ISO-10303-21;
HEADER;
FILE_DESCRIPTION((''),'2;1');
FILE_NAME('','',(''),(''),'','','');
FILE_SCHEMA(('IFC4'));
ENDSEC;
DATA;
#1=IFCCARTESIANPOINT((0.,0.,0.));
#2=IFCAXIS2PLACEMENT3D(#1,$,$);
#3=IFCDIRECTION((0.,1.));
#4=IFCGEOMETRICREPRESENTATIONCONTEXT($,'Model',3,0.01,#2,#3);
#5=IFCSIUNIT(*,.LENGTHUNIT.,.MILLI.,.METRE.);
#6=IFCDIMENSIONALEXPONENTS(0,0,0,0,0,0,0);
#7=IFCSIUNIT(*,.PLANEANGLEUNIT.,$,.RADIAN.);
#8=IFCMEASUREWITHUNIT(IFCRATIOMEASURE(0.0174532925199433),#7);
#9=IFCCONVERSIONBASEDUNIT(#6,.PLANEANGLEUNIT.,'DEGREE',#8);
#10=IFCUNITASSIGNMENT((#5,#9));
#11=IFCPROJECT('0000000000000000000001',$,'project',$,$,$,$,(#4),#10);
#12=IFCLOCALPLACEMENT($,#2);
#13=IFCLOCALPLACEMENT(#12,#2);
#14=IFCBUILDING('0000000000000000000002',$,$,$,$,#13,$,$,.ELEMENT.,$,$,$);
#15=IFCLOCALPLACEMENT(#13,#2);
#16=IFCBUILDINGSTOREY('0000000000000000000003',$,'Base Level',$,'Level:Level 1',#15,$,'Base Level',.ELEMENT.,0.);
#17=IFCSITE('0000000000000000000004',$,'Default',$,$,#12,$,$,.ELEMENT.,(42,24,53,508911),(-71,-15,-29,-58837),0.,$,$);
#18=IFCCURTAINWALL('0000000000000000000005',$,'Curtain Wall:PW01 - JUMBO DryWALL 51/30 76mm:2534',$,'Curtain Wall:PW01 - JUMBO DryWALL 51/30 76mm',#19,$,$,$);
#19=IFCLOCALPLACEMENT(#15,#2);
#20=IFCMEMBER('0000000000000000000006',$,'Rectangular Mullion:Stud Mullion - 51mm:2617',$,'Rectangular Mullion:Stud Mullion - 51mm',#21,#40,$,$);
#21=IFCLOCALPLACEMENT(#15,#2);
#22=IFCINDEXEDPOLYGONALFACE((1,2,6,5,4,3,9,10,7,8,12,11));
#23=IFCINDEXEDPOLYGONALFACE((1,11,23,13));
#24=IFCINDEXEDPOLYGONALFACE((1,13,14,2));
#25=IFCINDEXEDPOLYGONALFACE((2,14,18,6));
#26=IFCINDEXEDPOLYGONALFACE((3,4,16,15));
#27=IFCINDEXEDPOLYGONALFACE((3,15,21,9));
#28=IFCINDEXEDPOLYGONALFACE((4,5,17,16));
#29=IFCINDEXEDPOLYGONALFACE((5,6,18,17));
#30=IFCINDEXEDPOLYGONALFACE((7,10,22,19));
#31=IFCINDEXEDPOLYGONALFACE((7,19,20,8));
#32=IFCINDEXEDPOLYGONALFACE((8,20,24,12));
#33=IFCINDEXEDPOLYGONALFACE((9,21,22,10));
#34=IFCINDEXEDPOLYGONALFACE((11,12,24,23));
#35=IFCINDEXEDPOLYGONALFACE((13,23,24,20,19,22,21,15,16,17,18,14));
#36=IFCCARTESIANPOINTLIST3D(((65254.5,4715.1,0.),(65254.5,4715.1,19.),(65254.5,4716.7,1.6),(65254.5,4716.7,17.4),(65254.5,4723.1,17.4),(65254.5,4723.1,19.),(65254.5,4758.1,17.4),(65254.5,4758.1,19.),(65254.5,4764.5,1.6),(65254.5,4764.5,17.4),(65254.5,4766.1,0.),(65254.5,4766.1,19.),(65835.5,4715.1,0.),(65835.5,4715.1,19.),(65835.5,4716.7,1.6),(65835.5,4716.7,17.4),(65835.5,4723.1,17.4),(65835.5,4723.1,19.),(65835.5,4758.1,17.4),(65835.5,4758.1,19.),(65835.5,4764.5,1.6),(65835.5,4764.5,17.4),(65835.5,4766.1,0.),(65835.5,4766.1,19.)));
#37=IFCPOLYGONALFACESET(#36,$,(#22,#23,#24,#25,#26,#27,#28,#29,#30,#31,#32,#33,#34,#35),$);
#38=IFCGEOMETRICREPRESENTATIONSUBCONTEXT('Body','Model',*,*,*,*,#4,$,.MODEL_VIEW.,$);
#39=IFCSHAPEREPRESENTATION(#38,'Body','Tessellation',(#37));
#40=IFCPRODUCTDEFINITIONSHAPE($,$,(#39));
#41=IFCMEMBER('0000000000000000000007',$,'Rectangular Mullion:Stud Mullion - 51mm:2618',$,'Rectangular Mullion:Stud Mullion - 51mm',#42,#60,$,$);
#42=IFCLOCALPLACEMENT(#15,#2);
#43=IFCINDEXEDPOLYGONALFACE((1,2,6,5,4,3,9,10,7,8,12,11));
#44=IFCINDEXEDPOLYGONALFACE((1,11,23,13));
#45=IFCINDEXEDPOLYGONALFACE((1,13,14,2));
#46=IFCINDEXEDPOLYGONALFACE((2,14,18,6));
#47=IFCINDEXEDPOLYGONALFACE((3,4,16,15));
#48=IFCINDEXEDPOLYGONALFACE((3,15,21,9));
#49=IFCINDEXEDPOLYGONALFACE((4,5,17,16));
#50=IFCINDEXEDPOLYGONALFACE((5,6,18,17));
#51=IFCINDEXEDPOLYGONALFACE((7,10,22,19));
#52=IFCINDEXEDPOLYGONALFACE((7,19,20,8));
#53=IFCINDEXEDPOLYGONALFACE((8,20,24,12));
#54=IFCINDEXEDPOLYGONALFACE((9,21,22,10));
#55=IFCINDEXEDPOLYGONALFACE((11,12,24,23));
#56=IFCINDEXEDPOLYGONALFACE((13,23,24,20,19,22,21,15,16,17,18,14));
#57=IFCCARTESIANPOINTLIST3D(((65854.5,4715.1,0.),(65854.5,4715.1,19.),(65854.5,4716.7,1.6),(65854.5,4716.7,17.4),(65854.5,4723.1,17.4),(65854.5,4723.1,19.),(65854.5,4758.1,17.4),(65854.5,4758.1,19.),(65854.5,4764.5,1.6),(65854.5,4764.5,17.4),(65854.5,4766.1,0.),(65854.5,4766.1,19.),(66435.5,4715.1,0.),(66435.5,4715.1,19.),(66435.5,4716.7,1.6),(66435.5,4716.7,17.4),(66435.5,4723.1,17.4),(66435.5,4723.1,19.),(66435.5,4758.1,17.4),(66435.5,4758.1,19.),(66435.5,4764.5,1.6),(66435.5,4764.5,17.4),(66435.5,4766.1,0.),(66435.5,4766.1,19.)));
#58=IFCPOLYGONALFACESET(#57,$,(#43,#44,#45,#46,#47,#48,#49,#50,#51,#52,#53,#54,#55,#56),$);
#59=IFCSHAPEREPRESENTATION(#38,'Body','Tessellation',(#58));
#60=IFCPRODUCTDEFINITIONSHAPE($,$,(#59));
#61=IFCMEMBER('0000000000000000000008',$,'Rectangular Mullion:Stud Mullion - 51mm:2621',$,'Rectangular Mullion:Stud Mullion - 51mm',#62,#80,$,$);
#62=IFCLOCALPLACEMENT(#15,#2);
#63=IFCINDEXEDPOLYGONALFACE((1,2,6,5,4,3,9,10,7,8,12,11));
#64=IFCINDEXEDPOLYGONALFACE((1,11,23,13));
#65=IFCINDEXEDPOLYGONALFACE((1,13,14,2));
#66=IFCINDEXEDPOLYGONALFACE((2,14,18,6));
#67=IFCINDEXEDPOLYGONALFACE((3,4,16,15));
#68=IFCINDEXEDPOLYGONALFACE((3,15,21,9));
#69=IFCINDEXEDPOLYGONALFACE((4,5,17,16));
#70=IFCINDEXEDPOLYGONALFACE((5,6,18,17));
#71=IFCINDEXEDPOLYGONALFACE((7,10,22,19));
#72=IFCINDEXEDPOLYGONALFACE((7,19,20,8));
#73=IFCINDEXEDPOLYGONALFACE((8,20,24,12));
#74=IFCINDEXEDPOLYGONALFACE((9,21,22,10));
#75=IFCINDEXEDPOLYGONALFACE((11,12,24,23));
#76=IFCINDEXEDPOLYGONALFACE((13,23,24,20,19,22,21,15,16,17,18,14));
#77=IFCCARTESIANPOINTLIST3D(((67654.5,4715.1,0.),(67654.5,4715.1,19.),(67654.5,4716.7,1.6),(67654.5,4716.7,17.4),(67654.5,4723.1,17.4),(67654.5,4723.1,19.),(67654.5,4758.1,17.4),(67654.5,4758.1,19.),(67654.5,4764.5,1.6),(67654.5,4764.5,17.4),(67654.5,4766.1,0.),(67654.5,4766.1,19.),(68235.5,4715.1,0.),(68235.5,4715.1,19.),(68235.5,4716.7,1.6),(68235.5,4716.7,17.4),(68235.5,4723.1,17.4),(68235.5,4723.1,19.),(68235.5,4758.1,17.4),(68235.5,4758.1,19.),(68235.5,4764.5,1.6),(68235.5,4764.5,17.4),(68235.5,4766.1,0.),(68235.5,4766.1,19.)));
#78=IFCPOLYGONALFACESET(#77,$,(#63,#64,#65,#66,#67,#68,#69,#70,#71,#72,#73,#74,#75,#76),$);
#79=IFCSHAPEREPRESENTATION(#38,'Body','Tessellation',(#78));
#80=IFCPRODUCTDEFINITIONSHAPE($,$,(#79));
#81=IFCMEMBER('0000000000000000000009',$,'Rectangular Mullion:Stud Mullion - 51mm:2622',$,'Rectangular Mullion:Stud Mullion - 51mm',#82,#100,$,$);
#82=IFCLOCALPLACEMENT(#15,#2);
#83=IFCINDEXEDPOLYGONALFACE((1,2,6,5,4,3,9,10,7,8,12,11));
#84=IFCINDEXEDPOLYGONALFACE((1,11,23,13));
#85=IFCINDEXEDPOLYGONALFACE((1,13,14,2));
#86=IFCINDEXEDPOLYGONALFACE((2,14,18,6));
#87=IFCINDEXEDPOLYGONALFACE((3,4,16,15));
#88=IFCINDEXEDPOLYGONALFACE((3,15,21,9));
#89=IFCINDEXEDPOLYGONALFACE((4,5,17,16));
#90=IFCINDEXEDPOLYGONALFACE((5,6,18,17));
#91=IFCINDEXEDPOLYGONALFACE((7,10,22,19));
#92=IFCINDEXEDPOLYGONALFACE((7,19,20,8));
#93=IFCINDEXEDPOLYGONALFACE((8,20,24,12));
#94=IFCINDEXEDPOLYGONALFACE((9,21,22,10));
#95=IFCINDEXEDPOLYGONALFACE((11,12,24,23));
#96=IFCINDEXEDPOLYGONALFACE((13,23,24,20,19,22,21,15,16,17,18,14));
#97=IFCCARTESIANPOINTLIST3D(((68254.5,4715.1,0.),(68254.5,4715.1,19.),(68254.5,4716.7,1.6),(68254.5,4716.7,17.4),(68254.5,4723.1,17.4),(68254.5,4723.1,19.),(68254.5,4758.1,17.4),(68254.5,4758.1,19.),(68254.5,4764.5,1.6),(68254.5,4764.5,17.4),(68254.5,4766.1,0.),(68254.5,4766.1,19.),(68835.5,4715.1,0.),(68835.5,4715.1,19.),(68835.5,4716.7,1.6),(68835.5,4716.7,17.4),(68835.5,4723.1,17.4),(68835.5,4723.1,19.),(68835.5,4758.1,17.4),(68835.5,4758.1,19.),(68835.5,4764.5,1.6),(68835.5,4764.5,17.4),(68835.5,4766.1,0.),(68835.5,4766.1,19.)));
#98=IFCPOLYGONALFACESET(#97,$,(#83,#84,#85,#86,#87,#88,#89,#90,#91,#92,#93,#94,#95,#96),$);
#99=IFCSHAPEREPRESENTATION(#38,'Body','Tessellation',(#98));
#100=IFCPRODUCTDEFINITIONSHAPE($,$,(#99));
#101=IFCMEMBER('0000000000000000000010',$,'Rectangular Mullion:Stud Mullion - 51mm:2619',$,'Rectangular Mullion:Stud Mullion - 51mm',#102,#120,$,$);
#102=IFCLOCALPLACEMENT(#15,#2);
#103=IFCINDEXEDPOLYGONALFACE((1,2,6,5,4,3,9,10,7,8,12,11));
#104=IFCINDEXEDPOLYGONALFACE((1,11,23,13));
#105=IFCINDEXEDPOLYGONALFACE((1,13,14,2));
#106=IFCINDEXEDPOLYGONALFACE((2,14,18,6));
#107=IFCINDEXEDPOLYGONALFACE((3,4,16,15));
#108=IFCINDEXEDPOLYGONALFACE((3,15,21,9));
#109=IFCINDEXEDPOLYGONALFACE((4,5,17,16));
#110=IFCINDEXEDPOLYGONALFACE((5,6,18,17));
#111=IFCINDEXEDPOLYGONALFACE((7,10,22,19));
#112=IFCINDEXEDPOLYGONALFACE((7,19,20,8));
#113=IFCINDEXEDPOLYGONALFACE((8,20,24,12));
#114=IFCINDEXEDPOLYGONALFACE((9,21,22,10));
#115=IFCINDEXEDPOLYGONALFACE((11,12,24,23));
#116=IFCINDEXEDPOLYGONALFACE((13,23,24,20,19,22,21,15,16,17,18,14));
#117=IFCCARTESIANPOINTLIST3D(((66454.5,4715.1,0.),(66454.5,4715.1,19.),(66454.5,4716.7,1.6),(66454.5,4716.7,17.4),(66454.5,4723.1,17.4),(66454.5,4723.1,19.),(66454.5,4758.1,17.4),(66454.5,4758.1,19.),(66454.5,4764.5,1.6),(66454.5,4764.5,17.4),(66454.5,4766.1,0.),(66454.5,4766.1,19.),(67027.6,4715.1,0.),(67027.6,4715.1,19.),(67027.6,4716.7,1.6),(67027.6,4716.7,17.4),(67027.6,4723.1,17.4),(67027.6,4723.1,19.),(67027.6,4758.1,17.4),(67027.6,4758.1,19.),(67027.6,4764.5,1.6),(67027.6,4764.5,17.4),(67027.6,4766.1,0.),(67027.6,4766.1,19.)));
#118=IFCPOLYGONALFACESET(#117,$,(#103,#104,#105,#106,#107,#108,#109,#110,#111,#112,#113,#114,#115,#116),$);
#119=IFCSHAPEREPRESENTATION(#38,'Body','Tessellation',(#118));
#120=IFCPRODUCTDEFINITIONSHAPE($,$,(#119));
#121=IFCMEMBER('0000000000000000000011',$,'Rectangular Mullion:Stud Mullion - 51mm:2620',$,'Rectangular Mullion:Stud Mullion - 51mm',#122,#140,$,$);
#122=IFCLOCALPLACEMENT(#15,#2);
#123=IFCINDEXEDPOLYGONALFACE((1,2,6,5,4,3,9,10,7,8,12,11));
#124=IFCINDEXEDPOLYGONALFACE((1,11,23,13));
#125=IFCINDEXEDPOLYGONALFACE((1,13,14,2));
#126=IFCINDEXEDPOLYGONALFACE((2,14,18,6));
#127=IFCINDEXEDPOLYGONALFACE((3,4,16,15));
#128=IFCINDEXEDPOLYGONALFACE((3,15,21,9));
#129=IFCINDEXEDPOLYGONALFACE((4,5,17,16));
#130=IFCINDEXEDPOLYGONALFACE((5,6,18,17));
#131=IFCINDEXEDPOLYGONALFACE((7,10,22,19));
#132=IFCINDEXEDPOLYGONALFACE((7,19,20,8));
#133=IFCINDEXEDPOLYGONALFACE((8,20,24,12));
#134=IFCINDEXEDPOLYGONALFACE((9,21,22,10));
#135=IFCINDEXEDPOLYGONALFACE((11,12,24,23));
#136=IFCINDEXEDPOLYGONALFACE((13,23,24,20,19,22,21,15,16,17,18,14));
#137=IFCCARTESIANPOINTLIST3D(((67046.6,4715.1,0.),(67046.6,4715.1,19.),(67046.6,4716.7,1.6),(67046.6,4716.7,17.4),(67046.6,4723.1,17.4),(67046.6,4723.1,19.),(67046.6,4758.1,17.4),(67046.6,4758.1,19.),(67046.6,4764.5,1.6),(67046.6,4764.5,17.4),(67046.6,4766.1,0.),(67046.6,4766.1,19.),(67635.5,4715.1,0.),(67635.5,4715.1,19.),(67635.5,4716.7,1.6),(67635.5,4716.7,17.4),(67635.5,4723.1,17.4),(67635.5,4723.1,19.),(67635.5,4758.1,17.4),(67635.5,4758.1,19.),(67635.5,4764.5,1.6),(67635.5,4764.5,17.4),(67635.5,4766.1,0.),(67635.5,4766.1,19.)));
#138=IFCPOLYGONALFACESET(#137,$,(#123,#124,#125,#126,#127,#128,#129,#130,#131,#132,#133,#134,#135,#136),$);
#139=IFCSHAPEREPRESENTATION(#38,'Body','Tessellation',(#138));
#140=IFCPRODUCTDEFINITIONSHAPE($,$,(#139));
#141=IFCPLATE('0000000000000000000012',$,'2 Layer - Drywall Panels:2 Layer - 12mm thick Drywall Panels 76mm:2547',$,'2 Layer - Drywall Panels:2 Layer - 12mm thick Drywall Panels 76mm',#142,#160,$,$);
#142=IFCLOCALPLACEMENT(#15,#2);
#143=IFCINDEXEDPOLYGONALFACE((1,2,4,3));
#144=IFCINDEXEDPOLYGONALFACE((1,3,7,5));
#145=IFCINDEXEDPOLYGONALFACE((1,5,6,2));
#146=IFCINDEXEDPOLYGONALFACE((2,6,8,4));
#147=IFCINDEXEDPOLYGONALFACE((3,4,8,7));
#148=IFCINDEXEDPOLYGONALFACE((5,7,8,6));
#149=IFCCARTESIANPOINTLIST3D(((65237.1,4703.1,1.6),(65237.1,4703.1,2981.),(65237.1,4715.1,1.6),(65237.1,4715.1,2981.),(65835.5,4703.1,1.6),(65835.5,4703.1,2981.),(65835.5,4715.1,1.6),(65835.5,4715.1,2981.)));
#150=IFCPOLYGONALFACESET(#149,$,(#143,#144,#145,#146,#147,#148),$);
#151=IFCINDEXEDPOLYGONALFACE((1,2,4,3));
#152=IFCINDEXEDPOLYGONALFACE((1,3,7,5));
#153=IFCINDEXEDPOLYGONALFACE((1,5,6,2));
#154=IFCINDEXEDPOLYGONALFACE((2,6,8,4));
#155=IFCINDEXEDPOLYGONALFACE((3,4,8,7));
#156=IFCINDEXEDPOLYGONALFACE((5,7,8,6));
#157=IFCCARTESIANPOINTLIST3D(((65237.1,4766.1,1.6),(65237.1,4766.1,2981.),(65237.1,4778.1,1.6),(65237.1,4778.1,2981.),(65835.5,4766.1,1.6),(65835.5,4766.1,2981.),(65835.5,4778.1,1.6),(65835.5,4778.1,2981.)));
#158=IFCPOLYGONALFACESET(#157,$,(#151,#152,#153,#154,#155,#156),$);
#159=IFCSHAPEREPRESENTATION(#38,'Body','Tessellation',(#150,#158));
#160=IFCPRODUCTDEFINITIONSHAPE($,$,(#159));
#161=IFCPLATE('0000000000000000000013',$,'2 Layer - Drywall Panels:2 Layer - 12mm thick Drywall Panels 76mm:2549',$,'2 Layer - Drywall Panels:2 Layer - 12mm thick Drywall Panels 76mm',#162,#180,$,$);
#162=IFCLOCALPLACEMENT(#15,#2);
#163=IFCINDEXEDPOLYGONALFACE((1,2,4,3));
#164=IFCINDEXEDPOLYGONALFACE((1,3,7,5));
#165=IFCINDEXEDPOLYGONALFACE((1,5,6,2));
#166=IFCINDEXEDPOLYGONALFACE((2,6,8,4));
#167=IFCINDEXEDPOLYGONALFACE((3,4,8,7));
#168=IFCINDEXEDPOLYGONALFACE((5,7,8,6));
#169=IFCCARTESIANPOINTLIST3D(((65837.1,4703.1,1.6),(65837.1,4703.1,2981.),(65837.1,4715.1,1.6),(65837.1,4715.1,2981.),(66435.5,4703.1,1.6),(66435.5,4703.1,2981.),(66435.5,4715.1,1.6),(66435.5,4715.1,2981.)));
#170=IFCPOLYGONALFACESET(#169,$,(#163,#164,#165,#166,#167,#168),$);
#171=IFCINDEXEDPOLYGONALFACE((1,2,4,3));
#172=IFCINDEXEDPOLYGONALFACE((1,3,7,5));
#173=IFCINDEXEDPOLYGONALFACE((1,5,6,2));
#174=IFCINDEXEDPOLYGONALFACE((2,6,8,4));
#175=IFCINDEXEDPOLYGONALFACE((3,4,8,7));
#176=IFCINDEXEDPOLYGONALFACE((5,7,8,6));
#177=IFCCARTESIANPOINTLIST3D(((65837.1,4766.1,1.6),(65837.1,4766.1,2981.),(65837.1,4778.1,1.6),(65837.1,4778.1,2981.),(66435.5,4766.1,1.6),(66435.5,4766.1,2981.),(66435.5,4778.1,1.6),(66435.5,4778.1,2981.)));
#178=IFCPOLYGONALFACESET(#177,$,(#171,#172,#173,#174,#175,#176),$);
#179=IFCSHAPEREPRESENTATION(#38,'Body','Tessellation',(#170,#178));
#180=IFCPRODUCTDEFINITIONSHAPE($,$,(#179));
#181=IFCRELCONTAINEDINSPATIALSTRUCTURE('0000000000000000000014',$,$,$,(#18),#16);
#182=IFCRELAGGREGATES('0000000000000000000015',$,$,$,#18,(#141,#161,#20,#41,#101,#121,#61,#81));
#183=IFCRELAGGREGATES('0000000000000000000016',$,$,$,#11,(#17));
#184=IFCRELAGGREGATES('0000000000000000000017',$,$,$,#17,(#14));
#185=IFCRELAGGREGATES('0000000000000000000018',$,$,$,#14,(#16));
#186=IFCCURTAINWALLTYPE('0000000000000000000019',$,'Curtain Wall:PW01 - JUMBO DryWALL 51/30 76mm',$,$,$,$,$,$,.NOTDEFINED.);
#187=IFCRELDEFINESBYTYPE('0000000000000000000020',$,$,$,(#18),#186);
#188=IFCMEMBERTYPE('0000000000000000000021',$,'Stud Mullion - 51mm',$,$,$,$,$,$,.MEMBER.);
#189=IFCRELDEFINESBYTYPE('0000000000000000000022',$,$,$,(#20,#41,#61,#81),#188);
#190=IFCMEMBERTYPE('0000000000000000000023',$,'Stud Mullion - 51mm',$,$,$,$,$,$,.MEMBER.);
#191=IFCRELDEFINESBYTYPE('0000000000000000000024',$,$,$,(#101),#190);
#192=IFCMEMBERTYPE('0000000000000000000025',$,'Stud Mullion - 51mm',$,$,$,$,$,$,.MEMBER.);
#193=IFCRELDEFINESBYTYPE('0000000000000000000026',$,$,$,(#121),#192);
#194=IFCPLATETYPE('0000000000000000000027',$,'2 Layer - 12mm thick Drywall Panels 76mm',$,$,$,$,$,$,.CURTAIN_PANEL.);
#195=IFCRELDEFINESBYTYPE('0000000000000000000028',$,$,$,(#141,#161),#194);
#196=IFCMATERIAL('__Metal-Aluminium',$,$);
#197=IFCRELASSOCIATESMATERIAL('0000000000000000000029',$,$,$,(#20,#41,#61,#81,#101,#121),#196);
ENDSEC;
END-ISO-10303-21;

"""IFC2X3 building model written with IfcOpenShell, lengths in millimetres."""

from ifc_helpers import new_model, entity, si_unit, converted_unit, direction, frame, frame_2d, origin, origin_2d_with_axis, place, context, subcontext, project, spatial, polyline, rectangle, outline, extrude, source, transform, mapped, material, type_object, type_shapes, element, aggregate, save


model = new_model("IFC2X3")

# Units and contexts
model_context = context("Model", 3, precision=0.01, world=origin(), true_north=direction((0.0, 1.0)))
body_context = subcontext(model_context, "Body", "Model", "MODEL_VIEW")
ifc_project = project(units=[si_unit("LENGTHUNIT", "METRE", prefix="MILLI"), converted_unit("PLANEANGLEUNIT", "DEGREE", entity("IfcRatioMeasure", 0.0174532925199433), si_unit("PLANEANGLEUNIT", "RADIAN"), dimensions=[0, 0, 0, 0, 0, 0, 0])], contexts=[model_context])

# Site, building, storey
site_placement = place(None, origin())
site = spatial("IfcSite", under=ifc_project, at=site_placement, Name="Default", CompositionType="ELEMENT", RefLatitude=(42, 24, 53, 508911), RefLongitude=(-71, -15, -29, -58837), RefElevation=0.0)
building_placement = place(site_placement, origin())
building = spatial("IfcBuilding", under=site, at=building_placement, CompositionType="ELEMENT")
storey_placement = place(building_placement, origin())
storey = spatial("IfcBuildingStorey", under=building, at=storey_placement, Name="Base Level", ObjectType="Level:Level 1", LongName="Base Level", CompositionType="ELEMENT", Elevation=0.0)

# Curtain wall, members, plates
curtain_wall_type = type_object("IfcCurtainWallType", Name="Curtain Wall:PW01 - JUMBO DryWALL 51/30 76mm", PredefinedType="NOTDEFINED")
curtain_wall_placement = place(building_placement, origin())
curtain_wall = element("IfcCurtainWall", 1, at=curtain_wall_placement, inside=storey, type_object=curtain_wall_type, Name="Curtain Wall:PW01 - JUMBO DryWALL 51/30 76mm:2534", ObjectType="Curtain Wall:PW01 - JUMBO DryWALL 51/30 76mm")
ifc_material = material(Name="__Metal-Aluminium")
member_type_1 = type_object("IfcMemberType", Name="Stud Mullion - 51mm", PredefinedType="MEMBER")
shared_shape_1 = source(origin(), body_context, "Body", "SweptSolid", [
    extrude(outline(polyline([(17.5, -6.6), (25.5, -6.6), (25.5, 12.4), (-25.5, 12.4), (-25.5, -6.6), (-17.5, -6.6), (-17.5, -5.0), (-23.9, -5.0), (-23.9, 10.8), (23.9, 10.8), (23.9, -5.0), (17.5, -5.0), (17.5, -6.6)])), frame((-12.4, 0.0, -581.0), z_axis=(0.0, 0.0, 1.0), x_axis=(0.0, -1.0, 0.0)), (0.0, 0.0, 1.0), 581.0),
])
type_shapes(member_type_1, [shared_shape_1])
member_1_placement = place(building_placement, frame((65254.5, 4740.6, 0.0), z_axis=(-1.0, 0.0, 0.0), x_axis=(0.0, 0.0, -1.0)))
member_1 = element("IfcMember", 2, at=member_1_placement, type_object=member_type_1, material=ifc_material, Name="Rectangular Mullion:Stud Mullion - 51mm:2617", ObjectType="Rectangular Mullion:Stud Mullion - 51mm", context=body_context, shape_type="MappedRepresentation", body=[
    mapped(shared_shape_1, transform((0.0, 0.0, 0.0), scale=1.0)),
])
member_2_placement = place(building_placement, frame((65854.5, 4740.6, 0.0), z_axis=(-1.0, 0.0, 0.0), x_axis=(0.0, 0.0, -1.0)))
member_2 = element("IfcMember", 3, at=member_2_placement, type_object=member_type_1, material=ifc_material, Name="Rectangular Mullion:Stud Mullion - 51mm:2618", ObjectType="Rectangular Mullion:Stud Mullion - 51mm", context=body_context, shape_type="MappedRepresentation", body=[
    mapped(shared_shape_1, transform((0.0, 0.0, 0.0), scale=1.0)),
])
member_3_placement = place(building_placement, frame((67654.5, 4740.6, 0.0), z_axis=(-1.0, 0.0, 0.0), x_axis=(0.0, 0.0, -1.0)))
member_3 = element("IfcMember", 4, at=member_3_placement, type_object=member_type_1, material=ifc_material, Name="Rectangular Mullion:Stud Mullion - 51mm:2621", ObjectType="Rectangular Mullion:Stud Mullion - 51mm", context=body_context, shape_type="MappedRepresentation", body=[
    mapped(shared_shape_1, transform((0.0, 0.0, 0.0), scale=1.0)),
])
member_4_placement = place(building_placement, frame((68254.5, 4740.6, 0.0), z_axis=(-1.0, 0.0, 0.0), x_axis=(0.0, 0.0, -1.0)))
member_4 = element("IfcMember", 5, at=member_4_placement, type_object=member_type_1, material=ifc_material, Name="Rectangular Mullion:Stud Mullion - 51mm:2622", ObjectType="Rectangular Mullion:Stud Mullion - 51mm", context=body_context, shape_type="MappedRepresentation", body=[
    mapped(shared_shape_1, transform((0.0, 0.0, 0.0), scale=1.0)),
])
member_type_2 = type_object("IfcMemberType", Name="Stud Mullion - 51mm", PredefinedType="MEMBER")
shared_shape_2 = source(origin(), body_context, "Body", "SweptSolid", [
    extrude(outline(polyline([(17.5, -6.6), (25.5, -6.6), (25.5, 12.4), (-25.5, 12.4), (-25.5, -6.6), (-17.5, -6.6), (-17.5, -5.0), (-23.9, -5.0), (-23.9, 10.8), (23.9, 10.8), (23.9, -5.0), (17.5, -5.0), (17.5, -6.6)])), frame((-12.4, 0.0, -573.1), z_axis=(0.0, 0.0, 1.0), x_axis=(0.0, -1.0, 0.0)), (0.0, 0.0, 1.0), 573.1),
])
type_shapes(member_type_2, [shared_shape_2])
member_5_placement = place(building_placement, frame((66454.5, 4740.6, 0.0), z_axis=(-1.0, 0.0, 0.0), x_axis=(0.0, 0.0, -1.0)))
member_5 = element("IfcMember", 6, at=member_5_placement, type_object=member_type_2, material=ifc_material, Name="Rectangular Mullion:Stud Mullion - 51mm:2619", ObjectType="Rectangular Mullion:Stud Mullion - 51mm", context=body_context, shape_type="MappedRepresentation", body=[
    mapped(shared_shape_2, transform((0.0, 0.0, 0.0), scale=1.0)),
])
member_type_3 = type_object("IfcMemberType", Name="Stud Mullion - 51mm", PredefinedType="MEMBER")
shared_shape_3 = source(origin(), body_context, "Body", "SweptSolid", [
    extrude(outline(polyline([(17.5, -6.6), (25.5, -6.6), (25.5, 12.4), (-25.5, 12.4), (-25.5, -6.6), (-17.5, -6.6), (-17.5, -5.0), (-23.9, -5.0), (-23.9, 10.8), (23.9, 10.8), (23.9, -5.0), (17.5, -5.0), (17.5, -6.6)])), frame((-12.4, 0.0, -588.9), z_axis=(0.0, 0.0, 1.0), x_axis=(0.0, -1.0, 0.0)), (0.0, 0.0, 1.0), 588.9),
])
type_shapes(member_type_3, [shared_shape_3])
member_6_placement = place(building_placement, frame((67046.6, 4740.6, 0.0), z_axis=(-1.0, 0.0, 0.0), x_axis=(0.0, 0.0, -1.0)))
member_6 = element("IfcMember", 7, at=member_6_placement, type_object=member_type_3, material=ifc_material, Name="Rectangular Mullion:Stud Mullion - 51mm:2620", ObjectType="Rectangular Mullion:Stud Mullion - 51mm", context=body_context, shape_type="MappedRepresentation", body=[
    mapped(shared_shape_3, transform((0.0, 0.0, 0.0), scale=1.0)),
])
plate_type_1 = type_object("IfcPlateType", Name="2 Layer - 12mm thick Drywall Panels 76mm", PredefinedType="CURTAIN_PANEL")
shared_shape_4 = source(origin(), body_context, "Body", "SweptSolid", [
    extrude(rectangle(XDim=598.4, YDim=12.0, at=origin_2d_with_axis()), frame((0.0, -31.5, 0.0), z_axis=(0.0, 0.0, 1.0), x_axis=(-1.0, 0.0, 0.0)), (0.0, 0.0, 1.0), 2979.4),
    extrude(rectangle(XDim=12.0, YDim=598.4, at=frame_2d((0.0, 0.0), x_axis=(1.0, 0.0))), frame((0.0, 31.5, 0.0), z_axis=(0.0, 0.0, 1.0), x_axis=(0.0, 1.0, 0.0)), (0.0, 0.0, 1.0), 2979.4),
])
type_shapes(plate_type_1, [shared_shape_4])
plate_1_placement = place(curtain_wall_placement, frame((65536.3, 4740.6, 1.6)))
plate_1 = element("IfcPlate", 8, at=plate_1_placement, type_object=plate_type_1, Name="2 Layer - Drywall Panels:2 Layer - 12mm thick Drywall Panels 76mm:2547", ObjectType="2 Layer - Drywall Panels:2 Layer - 12mm thick Drywall Panels 76mm", context=body_context, shape_type="MappedRepresentation", body=[
    mapped(shared_shape_4, transform((0.0, 0.0, 0.0), scale=1.0)),
])
plate_2_placement = place(curtain_wall_placement, frame((66136.3, 4740.6, 1.6)))
plate_2 = element("IfcPlate", 9, at=plate_2_placement, type_object=plate_type_1, Name="2 Layer - Drywall Panels:2 Layer - 12mm thick Drywall Panels 76mm:2549", ObjectType="2 Layer - Drywall Panels:2 Layer - 12mm thick Drywall Panels 76mm", context=body_context, shape_type="MappedRepresentation", body=[
    mapped(shared_shape_4, transform((0.0, 0.0, 0.0), scale=1.0)),
])
aggregate(curtain_wall, [plate_1, plate_2, member_1, member_2, member_5, member_6, member_3, member_4])

save(model, "model.ifc")
